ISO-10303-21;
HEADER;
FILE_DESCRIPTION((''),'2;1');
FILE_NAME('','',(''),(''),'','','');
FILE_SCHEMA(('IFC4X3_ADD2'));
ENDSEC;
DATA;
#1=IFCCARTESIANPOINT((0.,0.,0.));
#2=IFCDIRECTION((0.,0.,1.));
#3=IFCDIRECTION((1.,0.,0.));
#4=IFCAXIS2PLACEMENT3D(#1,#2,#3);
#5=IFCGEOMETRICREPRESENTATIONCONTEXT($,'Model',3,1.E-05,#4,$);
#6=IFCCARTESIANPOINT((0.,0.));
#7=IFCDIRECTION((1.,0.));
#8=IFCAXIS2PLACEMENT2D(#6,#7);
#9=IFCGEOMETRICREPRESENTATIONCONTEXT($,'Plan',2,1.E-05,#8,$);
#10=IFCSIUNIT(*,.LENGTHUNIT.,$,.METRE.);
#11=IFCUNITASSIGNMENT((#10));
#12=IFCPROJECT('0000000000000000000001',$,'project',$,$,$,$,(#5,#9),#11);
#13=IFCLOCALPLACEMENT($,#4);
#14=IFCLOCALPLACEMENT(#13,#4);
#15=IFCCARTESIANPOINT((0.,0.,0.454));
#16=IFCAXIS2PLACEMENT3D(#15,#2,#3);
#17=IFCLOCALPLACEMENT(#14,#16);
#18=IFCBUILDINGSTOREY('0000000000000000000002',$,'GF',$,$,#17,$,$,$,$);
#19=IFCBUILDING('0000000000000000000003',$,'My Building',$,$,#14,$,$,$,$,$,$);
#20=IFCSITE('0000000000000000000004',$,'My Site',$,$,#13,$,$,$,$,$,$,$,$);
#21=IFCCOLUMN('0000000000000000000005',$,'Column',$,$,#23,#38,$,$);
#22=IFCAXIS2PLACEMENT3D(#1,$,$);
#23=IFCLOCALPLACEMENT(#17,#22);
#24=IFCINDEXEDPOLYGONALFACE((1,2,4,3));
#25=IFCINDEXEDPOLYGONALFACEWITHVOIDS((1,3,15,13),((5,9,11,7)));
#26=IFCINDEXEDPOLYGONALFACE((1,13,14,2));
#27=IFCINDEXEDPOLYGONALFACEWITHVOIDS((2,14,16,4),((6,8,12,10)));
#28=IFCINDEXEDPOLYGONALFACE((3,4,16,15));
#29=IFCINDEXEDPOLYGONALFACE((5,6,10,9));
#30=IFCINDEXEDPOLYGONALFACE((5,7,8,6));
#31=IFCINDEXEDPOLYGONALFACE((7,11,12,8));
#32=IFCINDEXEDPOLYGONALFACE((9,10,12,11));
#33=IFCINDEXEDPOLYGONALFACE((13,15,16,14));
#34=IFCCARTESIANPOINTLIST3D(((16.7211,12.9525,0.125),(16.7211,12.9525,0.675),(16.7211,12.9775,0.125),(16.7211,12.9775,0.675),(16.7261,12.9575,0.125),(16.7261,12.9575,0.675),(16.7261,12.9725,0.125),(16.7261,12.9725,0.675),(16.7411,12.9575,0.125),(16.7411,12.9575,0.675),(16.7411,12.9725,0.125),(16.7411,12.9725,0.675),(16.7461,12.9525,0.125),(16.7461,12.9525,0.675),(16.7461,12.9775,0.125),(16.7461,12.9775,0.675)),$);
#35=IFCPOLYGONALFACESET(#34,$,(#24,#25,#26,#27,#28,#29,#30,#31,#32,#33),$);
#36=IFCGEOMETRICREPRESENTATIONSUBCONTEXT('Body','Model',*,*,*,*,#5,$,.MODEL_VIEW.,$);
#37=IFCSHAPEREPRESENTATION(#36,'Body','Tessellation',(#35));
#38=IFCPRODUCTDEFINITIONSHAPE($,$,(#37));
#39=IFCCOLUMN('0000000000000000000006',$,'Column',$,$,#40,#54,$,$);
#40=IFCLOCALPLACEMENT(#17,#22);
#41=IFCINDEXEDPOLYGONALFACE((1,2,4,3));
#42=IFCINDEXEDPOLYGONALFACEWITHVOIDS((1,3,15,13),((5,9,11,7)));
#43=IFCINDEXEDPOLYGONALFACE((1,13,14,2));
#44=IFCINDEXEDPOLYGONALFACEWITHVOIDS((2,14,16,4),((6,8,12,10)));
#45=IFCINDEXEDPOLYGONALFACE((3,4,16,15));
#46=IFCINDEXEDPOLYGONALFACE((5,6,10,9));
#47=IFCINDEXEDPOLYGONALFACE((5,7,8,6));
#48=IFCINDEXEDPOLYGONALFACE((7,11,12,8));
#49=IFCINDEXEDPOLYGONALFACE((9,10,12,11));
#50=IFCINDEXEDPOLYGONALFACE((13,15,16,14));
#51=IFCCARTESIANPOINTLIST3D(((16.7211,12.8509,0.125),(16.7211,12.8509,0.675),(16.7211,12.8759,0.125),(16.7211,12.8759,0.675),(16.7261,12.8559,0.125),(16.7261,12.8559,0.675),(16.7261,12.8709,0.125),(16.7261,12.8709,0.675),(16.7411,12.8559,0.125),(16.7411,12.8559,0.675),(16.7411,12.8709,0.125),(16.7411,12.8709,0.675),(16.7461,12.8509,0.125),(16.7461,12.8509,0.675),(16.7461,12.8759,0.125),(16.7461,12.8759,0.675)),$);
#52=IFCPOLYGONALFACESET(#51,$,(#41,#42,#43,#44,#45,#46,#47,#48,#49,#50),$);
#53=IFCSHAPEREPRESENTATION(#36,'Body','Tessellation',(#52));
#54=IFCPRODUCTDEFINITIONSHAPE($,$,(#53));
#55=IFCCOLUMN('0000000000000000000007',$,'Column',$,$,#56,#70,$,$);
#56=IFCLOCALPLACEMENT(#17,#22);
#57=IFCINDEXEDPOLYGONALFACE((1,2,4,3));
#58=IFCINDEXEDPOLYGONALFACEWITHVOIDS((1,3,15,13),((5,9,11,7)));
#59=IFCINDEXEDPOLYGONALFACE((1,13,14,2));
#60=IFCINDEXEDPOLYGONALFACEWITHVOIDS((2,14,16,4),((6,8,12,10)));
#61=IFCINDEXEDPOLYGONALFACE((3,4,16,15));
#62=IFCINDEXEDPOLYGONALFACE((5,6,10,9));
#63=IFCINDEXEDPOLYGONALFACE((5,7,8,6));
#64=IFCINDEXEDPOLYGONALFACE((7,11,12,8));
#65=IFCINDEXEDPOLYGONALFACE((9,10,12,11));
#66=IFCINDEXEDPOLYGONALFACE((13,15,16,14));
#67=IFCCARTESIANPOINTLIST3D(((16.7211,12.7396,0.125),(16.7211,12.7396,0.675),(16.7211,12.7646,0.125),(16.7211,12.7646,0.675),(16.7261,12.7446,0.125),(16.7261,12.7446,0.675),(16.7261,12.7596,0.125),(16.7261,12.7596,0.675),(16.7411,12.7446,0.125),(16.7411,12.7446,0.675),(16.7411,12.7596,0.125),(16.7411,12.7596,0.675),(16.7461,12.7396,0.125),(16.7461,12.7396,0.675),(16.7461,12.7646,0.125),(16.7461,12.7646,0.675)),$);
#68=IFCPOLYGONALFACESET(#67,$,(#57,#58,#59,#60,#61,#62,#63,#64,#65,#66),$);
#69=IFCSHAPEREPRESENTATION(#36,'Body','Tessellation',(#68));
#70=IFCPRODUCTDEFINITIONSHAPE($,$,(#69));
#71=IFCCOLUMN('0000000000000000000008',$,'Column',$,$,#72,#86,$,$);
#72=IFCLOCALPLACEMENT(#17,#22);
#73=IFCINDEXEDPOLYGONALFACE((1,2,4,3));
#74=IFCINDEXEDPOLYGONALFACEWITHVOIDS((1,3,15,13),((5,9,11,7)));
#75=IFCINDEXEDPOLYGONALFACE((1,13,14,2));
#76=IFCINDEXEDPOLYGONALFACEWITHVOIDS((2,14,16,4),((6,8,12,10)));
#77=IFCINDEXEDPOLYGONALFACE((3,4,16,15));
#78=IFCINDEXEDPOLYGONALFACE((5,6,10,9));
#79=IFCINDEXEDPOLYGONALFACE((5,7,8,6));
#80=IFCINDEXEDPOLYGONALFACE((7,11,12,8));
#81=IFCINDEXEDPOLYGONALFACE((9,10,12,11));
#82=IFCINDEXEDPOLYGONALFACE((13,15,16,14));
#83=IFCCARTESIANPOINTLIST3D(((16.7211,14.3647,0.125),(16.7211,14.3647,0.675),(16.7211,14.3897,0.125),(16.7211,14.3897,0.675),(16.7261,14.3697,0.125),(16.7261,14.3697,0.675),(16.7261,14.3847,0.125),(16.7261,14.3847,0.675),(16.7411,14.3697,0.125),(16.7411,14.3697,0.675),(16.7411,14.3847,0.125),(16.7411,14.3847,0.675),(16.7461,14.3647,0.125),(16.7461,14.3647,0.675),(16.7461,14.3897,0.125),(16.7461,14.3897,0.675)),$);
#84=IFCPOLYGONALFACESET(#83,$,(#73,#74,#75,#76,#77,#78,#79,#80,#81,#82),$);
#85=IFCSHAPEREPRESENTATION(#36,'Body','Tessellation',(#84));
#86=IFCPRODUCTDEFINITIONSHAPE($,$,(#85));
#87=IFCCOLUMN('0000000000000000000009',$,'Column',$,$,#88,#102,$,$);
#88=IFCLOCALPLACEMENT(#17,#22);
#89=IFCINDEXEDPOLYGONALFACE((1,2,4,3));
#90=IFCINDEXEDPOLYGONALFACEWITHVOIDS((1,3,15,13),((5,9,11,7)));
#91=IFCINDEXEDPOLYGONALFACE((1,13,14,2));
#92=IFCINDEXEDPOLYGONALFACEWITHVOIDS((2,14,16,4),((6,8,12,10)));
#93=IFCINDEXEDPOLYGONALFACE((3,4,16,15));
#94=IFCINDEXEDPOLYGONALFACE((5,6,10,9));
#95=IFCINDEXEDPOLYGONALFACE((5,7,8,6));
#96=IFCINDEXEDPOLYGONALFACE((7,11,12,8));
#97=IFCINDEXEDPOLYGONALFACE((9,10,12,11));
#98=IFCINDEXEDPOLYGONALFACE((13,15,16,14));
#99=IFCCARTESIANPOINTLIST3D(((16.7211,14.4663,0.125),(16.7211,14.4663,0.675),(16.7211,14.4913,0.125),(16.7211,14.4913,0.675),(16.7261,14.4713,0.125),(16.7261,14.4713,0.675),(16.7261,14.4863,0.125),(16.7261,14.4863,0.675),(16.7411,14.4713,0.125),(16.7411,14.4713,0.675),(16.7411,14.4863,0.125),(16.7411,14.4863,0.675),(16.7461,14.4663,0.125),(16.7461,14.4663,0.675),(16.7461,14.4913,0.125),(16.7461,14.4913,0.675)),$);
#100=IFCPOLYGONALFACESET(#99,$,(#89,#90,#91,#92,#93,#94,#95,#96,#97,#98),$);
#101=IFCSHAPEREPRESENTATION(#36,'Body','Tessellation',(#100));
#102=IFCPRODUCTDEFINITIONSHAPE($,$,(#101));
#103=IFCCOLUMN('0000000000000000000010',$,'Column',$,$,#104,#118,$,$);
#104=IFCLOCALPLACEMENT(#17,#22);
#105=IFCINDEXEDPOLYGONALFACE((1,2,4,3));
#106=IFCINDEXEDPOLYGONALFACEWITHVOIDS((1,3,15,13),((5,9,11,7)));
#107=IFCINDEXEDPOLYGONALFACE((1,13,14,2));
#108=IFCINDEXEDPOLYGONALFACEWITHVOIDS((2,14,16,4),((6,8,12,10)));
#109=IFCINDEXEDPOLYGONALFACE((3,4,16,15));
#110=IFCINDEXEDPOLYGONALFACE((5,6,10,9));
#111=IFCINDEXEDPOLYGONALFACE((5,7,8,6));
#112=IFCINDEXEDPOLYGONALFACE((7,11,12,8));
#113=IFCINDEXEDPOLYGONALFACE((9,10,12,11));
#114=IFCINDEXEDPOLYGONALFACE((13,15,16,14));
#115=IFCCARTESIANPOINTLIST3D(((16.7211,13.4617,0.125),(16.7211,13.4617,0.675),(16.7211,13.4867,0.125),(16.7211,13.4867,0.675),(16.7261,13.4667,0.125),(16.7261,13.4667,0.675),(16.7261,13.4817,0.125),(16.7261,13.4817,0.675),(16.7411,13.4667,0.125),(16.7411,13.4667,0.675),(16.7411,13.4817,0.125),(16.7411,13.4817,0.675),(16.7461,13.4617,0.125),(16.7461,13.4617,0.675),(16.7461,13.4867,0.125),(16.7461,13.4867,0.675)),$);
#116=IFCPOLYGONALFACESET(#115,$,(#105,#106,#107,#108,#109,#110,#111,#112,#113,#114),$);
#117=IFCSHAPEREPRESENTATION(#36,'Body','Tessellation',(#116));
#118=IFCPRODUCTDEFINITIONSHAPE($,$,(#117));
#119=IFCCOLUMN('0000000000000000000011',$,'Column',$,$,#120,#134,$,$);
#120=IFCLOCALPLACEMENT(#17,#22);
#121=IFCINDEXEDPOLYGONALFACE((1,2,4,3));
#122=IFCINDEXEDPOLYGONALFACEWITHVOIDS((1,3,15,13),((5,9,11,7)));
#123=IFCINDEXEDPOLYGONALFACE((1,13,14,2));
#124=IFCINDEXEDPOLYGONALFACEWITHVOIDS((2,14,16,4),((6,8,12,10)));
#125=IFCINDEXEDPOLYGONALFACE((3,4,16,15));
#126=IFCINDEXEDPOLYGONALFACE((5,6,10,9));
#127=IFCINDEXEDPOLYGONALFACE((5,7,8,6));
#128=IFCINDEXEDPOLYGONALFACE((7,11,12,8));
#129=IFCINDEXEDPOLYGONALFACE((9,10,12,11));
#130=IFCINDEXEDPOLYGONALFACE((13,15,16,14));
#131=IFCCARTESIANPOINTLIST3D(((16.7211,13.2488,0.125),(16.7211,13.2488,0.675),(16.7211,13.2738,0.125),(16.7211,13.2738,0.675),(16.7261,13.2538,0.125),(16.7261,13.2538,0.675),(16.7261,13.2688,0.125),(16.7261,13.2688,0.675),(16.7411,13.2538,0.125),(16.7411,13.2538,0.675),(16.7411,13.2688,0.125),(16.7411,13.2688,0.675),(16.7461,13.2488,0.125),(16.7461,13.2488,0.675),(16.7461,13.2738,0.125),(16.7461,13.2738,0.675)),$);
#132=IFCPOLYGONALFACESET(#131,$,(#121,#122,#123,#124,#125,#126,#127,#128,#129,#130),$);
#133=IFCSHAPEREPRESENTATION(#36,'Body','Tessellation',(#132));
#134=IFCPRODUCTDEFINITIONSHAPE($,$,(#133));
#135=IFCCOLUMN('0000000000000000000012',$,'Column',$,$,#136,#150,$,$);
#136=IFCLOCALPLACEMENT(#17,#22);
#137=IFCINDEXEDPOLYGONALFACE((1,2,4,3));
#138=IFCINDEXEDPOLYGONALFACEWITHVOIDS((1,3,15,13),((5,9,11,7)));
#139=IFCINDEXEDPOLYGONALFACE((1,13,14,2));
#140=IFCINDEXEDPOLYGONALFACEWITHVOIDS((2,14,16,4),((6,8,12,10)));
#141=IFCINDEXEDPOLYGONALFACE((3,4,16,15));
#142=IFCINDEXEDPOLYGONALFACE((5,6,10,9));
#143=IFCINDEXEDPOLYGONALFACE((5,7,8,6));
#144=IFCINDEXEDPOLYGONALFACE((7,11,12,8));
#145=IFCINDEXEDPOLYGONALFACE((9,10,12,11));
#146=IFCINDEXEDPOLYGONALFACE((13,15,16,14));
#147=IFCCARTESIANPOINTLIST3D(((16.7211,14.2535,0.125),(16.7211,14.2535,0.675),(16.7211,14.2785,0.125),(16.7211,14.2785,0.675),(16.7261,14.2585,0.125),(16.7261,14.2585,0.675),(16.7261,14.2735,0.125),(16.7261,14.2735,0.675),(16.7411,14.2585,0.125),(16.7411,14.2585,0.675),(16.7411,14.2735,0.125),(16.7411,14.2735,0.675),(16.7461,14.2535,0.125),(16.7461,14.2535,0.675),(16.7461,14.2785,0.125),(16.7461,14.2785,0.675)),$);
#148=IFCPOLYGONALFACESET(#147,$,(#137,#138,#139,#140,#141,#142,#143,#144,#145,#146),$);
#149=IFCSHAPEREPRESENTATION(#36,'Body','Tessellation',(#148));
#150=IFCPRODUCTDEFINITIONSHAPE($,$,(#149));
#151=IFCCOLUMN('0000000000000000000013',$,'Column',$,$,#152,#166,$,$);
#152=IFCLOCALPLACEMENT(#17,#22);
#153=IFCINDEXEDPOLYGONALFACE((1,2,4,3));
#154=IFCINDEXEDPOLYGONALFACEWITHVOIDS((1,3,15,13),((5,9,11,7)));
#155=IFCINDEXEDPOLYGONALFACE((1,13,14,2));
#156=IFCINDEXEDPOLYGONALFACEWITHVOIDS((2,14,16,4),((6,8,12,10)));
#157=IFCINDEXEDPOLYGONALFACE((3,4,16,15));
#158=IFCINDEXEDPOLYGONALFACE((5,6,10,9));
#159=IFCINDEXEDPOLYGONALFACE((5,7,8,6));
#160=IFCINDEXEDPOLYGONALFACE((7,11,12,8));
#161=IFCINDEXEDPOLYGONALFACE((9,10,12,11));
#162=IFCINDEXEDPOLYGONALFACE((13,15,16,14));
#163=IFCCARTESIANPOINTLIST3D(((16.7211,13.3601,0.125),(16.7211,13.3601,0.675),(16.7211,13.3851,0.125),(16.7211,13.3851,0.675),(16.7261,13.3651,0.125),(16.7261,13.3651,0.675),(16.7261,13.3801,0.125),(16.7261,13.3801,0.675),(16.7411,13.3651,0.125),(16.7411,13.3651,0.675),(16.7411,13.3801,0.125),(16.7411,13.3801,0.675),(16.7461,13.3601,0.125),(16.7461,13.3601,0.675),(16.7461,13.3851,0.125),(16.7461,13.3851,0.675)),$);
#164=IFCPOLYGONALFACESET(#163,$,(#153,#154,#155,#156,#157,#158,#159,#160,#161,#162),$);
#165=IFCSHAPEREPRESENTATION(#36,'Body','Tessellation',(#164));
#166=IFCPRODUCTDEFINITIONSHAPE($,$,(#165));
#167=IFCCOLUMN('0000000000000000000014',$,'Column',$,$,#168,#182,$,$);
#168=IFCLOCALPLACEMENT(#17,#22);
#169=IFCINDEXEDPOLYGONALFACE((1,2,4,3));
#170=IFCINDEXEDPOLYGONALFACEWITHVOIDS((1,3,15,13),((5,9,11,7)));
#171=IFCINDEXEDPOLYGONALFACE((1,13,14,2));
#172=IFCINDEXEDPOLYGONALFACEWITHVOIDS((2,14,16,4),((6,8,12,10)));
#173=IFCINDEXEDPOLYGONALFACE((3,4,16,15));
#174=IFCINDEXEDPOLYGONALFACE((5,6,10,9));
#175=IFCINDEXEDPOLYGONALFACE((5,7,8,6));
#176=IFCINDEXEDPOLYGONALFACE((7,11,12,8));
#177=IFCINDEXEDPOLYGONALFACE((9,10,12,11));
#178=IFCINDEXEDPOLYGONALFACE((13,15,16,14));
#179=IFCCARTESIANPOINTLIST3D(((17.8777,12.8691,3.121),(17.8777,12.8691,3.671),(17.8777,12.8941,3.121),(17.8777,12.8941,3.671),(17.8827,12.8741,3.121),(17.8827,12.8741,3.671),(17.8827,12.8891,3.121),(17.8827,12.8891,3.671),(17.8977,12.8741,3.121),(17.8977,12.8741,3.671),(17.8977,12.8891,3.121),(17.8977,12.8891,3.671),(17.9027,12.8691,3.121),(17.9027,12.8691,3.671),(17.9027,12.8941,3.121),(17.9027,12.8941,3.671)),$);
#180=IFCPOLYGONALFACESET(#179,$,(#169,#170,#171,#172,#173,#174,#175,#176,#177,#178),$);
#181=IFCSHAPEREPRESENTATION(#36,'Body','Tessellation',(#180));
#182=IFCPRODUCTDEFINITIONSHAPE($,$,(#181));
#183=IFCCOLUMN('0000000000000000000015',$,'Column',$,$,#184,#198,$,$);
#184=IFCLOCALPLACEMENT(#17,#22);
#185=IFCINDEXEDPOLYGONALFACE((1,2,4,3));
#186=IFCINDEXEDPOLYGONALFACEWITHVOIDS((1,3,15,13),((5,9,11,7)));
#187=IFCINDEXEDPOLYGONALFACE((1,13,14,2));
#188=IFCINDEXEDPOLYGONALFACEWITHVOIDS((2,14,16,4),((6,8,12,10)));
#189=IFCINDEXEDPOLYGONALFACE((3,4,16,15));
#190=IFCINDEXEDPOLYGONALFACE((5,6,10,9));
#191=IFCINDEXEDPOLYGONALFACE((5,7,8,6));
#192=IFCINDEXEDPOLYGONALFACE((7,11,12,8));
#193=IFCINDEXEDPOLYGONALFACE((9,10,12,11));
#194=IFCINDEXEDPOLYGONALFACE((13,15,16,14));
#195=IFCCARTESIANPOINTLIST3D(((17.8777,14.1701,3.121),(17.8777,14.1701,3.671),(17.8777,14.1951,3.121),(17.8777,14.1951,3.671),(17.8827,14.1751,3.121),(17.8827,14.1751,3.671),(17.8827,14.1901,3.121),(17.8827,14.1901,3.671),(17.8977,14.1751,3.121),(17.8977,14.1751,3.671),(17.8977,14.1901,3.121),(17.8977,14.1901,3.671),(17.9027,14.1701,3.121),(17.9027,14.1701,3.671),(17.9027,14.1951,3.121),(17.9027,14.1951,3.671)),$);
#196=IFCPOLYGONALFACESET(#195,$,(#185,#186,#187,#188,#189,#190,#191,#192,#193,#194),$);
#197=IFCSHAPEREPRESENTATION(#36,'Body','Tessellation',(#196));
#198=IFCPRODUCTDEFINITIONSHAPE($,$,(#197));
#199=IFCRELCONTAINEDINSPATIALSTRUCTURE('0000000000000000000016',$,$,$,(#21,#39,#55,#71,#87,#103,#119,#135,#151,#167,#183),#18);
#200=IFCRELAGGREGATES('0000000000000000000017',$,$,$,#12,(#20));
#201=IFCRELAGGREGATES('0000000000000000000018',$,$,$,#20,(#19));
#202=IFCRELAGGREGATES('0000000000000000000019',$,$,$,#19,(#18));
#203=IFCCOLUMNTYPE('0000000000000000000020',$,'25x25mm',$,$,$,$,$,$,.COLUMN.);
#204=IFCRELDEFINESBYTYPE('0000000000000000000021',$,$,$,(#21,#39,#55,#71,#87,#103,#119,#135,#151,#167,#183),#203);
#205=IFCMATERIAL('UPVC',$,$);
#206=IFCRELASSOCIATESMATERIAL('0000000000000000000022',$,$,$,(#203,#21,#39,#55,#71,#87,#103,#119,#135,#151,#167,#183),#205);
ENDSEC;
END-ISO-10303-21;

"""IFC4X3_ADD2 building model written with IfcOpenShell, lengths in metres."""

from ifc_helpers import new_model, si_unit, frame, origin_with_axes, origin_2d_with_axis, place, context, subcontext, project, spatial, hollow_rectangle, extrude, material, material_profile, profile_set, profile_usage, type_object, element, save


model = new_model("IFC4X3_ADD2")

# Units and contexts
model_context = context("Model", 3, precision=1e-05, world=origin_with_axes())
plan_context = context("Plan", 2, precision=1e-05, world=origin_2d_with_axis())
body_context = subcontext(model_context, "Body", "Model", "MODEL_VIEW")
ifc_project = project(units=[si_unit("LENGTHUNIT", "METRE")], contexts=[model_context, plan_context])

# Site, building, storey
site_placement = place(None, origin_with_axes())
site = spatial("IfcSite", under=ifc_project, at=site_placement, Name="My Site")
building_placement = place(site_placement, origin_with_axes())
building = spatial("IfcBuilding", under=site, at=building_placement, Name="My Building")
storey_placement = place(building_placement, frame((0.0, 0.0, 0.454), z_axis=(0.0, 0.0, 1.0), x_axis=(1.0, 0.0, 0.0)))
storey = spatial("IfcBuildingStorey", under=building, at=storey_placement, Name="GF")

# Columns
ifc_material = material(Name="UPVC")
ifc_material_profile_1 = material_profile(ifc_material, hollow_rectangle(XDim=0.025, YDim=0.025, WallThickness=0.005))
ifc_profile_set_1 = profile_set([ifc_material_profile_1])
ifc_profile_usage_1 = profile_usage(ifc_profile_set_1)
column_type_1 = type_object("IfcColumnType", Name="25x25mm", PredefinedType="COLUMN", material=ifc_profile_set_1)
column_1_placement = place(storey_placement, frame((16.7336, 12.965, 0.125), z_axis=(0.0, 0.0, 1.0), x_axis=(0.0, -1.0, 0.0)))
element("IfcColumn", 1, at=column_1_placement, inside=storey, type_object=column_type_1, material=ifc_profile_usage_1, Name="Column", context=body_context, shape_type="SweptSolid", body=[
    extrude(hollow_rectangle(XDim=0.025, YDim=0.025, WallThickness=0.005), origin_with_axes(), (0.0, 0.0, 1.0), 0.55),
])
ifc_profile_usage_2 = profile_usage(ifc_profile_set_1)
column_2_placement = place(storey_placement, frame((16.7336, 12.8634, 0.125), z_axis=(0.0, 0.0, 1.0), x_axis=(0.0, -1.0, 0.0)))
element("IfcColumn", 2, at=column_2_placement, inside=storey, type_object=column_type_1, material=ifc_profile_usage_2, Name="Column", context=body_context, shape_type="SweptSolid", body=[
    extrude(hollow_rectangle(XDim=0.025, YDim=0.025, WallThickness=0.005), origin_with_axes(), (0.0, 0.0, 1.0), 0.55),
])
ifc_profile_usage_3 = profile_usage(ifc_profile_set_1)
column_3_placement = place(storey_placement, frame((16.7336, 12.7521, 0.125), z_axis=(0.0, 0.0, 1.0), x_axis=(0.0, -1.0, 0.0)))
element("IfcColumn", 3, at=column_3_placement, inside=storey, type_object=column_type_1, material=ifc_profile_usage_3, Name="Column", context=body_context, shape_type="SweptSolid", body=[
    extrude(hollow_rectangle(XDim=0.025, YDim=0.025, WallThickness=0.005), origin_with_axes(), (0.0, 0.0, 1.0), 0.55),
])
ifc_profile_usage_4 = profile_usage(ifc_profile_set_1)
column_4_placement = place(storey_placement, frame((16.7336, 14.3772, 0.125), z_axis=(0.0, 0.0, 1.0), x_axis=(0.0, -1.0, 0.0)))
element("IfcColumn", 4, at=column_4_placement, inside=storey, type_object=column_type_1, material=ifc_profile_usage_4, Name="Column", context=body_context, shape_type="SweptSolid", body=[
    extrude(hollow_rectangle(XDim=0.025, YDim=0.025, WallThickness=0.005), origin_with_axes(), (0.0, 0.0, 1.0), 0.55),
])
ifc_profile_usage_5 = profile_usage(ifc_profile_set_1)
column_5_placement = place(storey_placement, frame((16.7336, 14.4788, 0.125), z_axis=(0.0, 0.0, 1.0), x_axis=(0.0, -1.0, 0.0)))
element("IfcColumn", 5, at=column_5_placement, inside=storey, type_object=column_type_1, material=ifc_profile_usage_5, Name="Column", context=body_context, shape_type="SweptSolid", body=[
    extrude(hollow_rectangle(XDim=0.025, YDim=0.025, WallThickness=0.005), origin_with_axes(), (0.0, 0.0, 1.0), 0.55),
])
ifc_profile_usage_6 = profile_usage(ifc_profile_set_1)
column_6_placement = place(storey_placement, frame((16.7336, 13.4742, 0.125), z_axis=(0.0, 0.0, 1.0), x_axis=(0.0, -1.0, 0.0)))
element("IfcColumn", 6, at=column_6_placement, inside=storey, type_object=column_type_1, material=ifc_profile_usage_6, Name="Column", context=body_context, shape_type="SweptSolid", body=[
    extrude(hollow_rectangle(XDim=0.025, YDim=0.025, WallThickness=0.005), origin_with_axes(), (0.0, 0.0, 1.0), 0.55),
])
ifc_profile_usage_7 = profile_usage(ifc_profile_set_1)
column_7_placement = place(storey_placement, frame((16.7336, 13.2613, 0.125), z_axis=(0.0, 0.0, 1.0), x_axis=(0.0, -1.0, 0.0)))
element("IfcColumn", 7, at=column_7_placement, inside=storey, type_object=column_type_1, material=ifc_profile_usage_7, Name="Column", context=body_context, shape_type="SweptSolid", body=[
    extrude(hollow_rectangle(XDim=0.025, YDim=0.025, WallThickness=0.005), origin_with_axes(), (0.0, 0.0, 1.0), 0.55),
])
ifc_profile_usage_8 = profile_usage(ifc_profile_set_1)
column_8_placement = place(storey_placement, frame((16.7336, 14.266, 0.125), z_axis=(0.0, 0.0, 1.0), x_axis=(0.0, -1.0, 0.0)))
element("IfcColumn", 8, at=column_8_placement, inside=storey, type_object=column_type_1, material=ifc_profile_usage_8, Name="Column", context=body_context, shape_type="SweptSolid", body=[
    extrude(hollow_rectangle(XDim=0.025, YDim=0.025, WallThickness=0.005), origin_with_axes(), (0.0, 0.0, 1.0), 0.55),
])
ifc_profile_usage_9 = profile_usage(ifc_profile_set_1)
column_9_placement = place(storey_placement, frame((16.7336, 13.3726, 0.125), z_axis=(0.0, 0.0, 1.0), x_axis=(0.0, -1.0, 0.0)))
element("IfcColumn", 9, at=column_9_placement, inside=storey, type_object=column_type_1, material=ifc_profile_usage_9, Name="Column", context=body_context, shape_type="SweptSolid", body=[
    extrude(hollow_rectangle(XDim=0.025, YDim=0.025, WallThickness=0.005), origin_with_axes(), (0.0, 0.0, 1.0), 0.55),
])
ifc_profile_usage_10 = profile_usage(ifc_profile_set_1)
column_10_placement = place(storey_placement, frame((17.8902, 12.8816, 3.121), z_axis=(0.0, 0.0, 1.0), x_axis=(0.0, -1.0, 0.0)))
element("IfcColumn", 10, at=column_10_placement, inside=storey, type_object=column_type_1, material=ifc_profile_usage_10, Name="Column", context=body_context, shape_type="SweptSolid", body=[
    extrude(hollow_rectangle(XDim=0.025, YDim=0.025, WallThickness=0.005), origin_with_axes(), (0.0, 0.0, 1.0), 0.55),
])
ifc_profile_usage_11 = profile_usage(ifc_profile_set_1)
column_11_placement = place(storey_placement, frame((17.8902, 14.1826, 3.121), z_axis=(0.0, 0.0, 1.0), x_axis=(0.0, -1.0, 0.0)))
element("IfcColumn", 11, at=column_11_placement, inside=storey, type_object=column_type_1, material=ifc_profile_usage_11, Name="Column", context=body_context, shape_type="SweptSolid", body=[
    extrude(hollow_rectangle(XDim=0.025, YDim=0.025, WallThickness=0.005), origin_with_axes(), (0.0, 0.0, 1.0), 0.55),
])

save(model, "model.ifc")
